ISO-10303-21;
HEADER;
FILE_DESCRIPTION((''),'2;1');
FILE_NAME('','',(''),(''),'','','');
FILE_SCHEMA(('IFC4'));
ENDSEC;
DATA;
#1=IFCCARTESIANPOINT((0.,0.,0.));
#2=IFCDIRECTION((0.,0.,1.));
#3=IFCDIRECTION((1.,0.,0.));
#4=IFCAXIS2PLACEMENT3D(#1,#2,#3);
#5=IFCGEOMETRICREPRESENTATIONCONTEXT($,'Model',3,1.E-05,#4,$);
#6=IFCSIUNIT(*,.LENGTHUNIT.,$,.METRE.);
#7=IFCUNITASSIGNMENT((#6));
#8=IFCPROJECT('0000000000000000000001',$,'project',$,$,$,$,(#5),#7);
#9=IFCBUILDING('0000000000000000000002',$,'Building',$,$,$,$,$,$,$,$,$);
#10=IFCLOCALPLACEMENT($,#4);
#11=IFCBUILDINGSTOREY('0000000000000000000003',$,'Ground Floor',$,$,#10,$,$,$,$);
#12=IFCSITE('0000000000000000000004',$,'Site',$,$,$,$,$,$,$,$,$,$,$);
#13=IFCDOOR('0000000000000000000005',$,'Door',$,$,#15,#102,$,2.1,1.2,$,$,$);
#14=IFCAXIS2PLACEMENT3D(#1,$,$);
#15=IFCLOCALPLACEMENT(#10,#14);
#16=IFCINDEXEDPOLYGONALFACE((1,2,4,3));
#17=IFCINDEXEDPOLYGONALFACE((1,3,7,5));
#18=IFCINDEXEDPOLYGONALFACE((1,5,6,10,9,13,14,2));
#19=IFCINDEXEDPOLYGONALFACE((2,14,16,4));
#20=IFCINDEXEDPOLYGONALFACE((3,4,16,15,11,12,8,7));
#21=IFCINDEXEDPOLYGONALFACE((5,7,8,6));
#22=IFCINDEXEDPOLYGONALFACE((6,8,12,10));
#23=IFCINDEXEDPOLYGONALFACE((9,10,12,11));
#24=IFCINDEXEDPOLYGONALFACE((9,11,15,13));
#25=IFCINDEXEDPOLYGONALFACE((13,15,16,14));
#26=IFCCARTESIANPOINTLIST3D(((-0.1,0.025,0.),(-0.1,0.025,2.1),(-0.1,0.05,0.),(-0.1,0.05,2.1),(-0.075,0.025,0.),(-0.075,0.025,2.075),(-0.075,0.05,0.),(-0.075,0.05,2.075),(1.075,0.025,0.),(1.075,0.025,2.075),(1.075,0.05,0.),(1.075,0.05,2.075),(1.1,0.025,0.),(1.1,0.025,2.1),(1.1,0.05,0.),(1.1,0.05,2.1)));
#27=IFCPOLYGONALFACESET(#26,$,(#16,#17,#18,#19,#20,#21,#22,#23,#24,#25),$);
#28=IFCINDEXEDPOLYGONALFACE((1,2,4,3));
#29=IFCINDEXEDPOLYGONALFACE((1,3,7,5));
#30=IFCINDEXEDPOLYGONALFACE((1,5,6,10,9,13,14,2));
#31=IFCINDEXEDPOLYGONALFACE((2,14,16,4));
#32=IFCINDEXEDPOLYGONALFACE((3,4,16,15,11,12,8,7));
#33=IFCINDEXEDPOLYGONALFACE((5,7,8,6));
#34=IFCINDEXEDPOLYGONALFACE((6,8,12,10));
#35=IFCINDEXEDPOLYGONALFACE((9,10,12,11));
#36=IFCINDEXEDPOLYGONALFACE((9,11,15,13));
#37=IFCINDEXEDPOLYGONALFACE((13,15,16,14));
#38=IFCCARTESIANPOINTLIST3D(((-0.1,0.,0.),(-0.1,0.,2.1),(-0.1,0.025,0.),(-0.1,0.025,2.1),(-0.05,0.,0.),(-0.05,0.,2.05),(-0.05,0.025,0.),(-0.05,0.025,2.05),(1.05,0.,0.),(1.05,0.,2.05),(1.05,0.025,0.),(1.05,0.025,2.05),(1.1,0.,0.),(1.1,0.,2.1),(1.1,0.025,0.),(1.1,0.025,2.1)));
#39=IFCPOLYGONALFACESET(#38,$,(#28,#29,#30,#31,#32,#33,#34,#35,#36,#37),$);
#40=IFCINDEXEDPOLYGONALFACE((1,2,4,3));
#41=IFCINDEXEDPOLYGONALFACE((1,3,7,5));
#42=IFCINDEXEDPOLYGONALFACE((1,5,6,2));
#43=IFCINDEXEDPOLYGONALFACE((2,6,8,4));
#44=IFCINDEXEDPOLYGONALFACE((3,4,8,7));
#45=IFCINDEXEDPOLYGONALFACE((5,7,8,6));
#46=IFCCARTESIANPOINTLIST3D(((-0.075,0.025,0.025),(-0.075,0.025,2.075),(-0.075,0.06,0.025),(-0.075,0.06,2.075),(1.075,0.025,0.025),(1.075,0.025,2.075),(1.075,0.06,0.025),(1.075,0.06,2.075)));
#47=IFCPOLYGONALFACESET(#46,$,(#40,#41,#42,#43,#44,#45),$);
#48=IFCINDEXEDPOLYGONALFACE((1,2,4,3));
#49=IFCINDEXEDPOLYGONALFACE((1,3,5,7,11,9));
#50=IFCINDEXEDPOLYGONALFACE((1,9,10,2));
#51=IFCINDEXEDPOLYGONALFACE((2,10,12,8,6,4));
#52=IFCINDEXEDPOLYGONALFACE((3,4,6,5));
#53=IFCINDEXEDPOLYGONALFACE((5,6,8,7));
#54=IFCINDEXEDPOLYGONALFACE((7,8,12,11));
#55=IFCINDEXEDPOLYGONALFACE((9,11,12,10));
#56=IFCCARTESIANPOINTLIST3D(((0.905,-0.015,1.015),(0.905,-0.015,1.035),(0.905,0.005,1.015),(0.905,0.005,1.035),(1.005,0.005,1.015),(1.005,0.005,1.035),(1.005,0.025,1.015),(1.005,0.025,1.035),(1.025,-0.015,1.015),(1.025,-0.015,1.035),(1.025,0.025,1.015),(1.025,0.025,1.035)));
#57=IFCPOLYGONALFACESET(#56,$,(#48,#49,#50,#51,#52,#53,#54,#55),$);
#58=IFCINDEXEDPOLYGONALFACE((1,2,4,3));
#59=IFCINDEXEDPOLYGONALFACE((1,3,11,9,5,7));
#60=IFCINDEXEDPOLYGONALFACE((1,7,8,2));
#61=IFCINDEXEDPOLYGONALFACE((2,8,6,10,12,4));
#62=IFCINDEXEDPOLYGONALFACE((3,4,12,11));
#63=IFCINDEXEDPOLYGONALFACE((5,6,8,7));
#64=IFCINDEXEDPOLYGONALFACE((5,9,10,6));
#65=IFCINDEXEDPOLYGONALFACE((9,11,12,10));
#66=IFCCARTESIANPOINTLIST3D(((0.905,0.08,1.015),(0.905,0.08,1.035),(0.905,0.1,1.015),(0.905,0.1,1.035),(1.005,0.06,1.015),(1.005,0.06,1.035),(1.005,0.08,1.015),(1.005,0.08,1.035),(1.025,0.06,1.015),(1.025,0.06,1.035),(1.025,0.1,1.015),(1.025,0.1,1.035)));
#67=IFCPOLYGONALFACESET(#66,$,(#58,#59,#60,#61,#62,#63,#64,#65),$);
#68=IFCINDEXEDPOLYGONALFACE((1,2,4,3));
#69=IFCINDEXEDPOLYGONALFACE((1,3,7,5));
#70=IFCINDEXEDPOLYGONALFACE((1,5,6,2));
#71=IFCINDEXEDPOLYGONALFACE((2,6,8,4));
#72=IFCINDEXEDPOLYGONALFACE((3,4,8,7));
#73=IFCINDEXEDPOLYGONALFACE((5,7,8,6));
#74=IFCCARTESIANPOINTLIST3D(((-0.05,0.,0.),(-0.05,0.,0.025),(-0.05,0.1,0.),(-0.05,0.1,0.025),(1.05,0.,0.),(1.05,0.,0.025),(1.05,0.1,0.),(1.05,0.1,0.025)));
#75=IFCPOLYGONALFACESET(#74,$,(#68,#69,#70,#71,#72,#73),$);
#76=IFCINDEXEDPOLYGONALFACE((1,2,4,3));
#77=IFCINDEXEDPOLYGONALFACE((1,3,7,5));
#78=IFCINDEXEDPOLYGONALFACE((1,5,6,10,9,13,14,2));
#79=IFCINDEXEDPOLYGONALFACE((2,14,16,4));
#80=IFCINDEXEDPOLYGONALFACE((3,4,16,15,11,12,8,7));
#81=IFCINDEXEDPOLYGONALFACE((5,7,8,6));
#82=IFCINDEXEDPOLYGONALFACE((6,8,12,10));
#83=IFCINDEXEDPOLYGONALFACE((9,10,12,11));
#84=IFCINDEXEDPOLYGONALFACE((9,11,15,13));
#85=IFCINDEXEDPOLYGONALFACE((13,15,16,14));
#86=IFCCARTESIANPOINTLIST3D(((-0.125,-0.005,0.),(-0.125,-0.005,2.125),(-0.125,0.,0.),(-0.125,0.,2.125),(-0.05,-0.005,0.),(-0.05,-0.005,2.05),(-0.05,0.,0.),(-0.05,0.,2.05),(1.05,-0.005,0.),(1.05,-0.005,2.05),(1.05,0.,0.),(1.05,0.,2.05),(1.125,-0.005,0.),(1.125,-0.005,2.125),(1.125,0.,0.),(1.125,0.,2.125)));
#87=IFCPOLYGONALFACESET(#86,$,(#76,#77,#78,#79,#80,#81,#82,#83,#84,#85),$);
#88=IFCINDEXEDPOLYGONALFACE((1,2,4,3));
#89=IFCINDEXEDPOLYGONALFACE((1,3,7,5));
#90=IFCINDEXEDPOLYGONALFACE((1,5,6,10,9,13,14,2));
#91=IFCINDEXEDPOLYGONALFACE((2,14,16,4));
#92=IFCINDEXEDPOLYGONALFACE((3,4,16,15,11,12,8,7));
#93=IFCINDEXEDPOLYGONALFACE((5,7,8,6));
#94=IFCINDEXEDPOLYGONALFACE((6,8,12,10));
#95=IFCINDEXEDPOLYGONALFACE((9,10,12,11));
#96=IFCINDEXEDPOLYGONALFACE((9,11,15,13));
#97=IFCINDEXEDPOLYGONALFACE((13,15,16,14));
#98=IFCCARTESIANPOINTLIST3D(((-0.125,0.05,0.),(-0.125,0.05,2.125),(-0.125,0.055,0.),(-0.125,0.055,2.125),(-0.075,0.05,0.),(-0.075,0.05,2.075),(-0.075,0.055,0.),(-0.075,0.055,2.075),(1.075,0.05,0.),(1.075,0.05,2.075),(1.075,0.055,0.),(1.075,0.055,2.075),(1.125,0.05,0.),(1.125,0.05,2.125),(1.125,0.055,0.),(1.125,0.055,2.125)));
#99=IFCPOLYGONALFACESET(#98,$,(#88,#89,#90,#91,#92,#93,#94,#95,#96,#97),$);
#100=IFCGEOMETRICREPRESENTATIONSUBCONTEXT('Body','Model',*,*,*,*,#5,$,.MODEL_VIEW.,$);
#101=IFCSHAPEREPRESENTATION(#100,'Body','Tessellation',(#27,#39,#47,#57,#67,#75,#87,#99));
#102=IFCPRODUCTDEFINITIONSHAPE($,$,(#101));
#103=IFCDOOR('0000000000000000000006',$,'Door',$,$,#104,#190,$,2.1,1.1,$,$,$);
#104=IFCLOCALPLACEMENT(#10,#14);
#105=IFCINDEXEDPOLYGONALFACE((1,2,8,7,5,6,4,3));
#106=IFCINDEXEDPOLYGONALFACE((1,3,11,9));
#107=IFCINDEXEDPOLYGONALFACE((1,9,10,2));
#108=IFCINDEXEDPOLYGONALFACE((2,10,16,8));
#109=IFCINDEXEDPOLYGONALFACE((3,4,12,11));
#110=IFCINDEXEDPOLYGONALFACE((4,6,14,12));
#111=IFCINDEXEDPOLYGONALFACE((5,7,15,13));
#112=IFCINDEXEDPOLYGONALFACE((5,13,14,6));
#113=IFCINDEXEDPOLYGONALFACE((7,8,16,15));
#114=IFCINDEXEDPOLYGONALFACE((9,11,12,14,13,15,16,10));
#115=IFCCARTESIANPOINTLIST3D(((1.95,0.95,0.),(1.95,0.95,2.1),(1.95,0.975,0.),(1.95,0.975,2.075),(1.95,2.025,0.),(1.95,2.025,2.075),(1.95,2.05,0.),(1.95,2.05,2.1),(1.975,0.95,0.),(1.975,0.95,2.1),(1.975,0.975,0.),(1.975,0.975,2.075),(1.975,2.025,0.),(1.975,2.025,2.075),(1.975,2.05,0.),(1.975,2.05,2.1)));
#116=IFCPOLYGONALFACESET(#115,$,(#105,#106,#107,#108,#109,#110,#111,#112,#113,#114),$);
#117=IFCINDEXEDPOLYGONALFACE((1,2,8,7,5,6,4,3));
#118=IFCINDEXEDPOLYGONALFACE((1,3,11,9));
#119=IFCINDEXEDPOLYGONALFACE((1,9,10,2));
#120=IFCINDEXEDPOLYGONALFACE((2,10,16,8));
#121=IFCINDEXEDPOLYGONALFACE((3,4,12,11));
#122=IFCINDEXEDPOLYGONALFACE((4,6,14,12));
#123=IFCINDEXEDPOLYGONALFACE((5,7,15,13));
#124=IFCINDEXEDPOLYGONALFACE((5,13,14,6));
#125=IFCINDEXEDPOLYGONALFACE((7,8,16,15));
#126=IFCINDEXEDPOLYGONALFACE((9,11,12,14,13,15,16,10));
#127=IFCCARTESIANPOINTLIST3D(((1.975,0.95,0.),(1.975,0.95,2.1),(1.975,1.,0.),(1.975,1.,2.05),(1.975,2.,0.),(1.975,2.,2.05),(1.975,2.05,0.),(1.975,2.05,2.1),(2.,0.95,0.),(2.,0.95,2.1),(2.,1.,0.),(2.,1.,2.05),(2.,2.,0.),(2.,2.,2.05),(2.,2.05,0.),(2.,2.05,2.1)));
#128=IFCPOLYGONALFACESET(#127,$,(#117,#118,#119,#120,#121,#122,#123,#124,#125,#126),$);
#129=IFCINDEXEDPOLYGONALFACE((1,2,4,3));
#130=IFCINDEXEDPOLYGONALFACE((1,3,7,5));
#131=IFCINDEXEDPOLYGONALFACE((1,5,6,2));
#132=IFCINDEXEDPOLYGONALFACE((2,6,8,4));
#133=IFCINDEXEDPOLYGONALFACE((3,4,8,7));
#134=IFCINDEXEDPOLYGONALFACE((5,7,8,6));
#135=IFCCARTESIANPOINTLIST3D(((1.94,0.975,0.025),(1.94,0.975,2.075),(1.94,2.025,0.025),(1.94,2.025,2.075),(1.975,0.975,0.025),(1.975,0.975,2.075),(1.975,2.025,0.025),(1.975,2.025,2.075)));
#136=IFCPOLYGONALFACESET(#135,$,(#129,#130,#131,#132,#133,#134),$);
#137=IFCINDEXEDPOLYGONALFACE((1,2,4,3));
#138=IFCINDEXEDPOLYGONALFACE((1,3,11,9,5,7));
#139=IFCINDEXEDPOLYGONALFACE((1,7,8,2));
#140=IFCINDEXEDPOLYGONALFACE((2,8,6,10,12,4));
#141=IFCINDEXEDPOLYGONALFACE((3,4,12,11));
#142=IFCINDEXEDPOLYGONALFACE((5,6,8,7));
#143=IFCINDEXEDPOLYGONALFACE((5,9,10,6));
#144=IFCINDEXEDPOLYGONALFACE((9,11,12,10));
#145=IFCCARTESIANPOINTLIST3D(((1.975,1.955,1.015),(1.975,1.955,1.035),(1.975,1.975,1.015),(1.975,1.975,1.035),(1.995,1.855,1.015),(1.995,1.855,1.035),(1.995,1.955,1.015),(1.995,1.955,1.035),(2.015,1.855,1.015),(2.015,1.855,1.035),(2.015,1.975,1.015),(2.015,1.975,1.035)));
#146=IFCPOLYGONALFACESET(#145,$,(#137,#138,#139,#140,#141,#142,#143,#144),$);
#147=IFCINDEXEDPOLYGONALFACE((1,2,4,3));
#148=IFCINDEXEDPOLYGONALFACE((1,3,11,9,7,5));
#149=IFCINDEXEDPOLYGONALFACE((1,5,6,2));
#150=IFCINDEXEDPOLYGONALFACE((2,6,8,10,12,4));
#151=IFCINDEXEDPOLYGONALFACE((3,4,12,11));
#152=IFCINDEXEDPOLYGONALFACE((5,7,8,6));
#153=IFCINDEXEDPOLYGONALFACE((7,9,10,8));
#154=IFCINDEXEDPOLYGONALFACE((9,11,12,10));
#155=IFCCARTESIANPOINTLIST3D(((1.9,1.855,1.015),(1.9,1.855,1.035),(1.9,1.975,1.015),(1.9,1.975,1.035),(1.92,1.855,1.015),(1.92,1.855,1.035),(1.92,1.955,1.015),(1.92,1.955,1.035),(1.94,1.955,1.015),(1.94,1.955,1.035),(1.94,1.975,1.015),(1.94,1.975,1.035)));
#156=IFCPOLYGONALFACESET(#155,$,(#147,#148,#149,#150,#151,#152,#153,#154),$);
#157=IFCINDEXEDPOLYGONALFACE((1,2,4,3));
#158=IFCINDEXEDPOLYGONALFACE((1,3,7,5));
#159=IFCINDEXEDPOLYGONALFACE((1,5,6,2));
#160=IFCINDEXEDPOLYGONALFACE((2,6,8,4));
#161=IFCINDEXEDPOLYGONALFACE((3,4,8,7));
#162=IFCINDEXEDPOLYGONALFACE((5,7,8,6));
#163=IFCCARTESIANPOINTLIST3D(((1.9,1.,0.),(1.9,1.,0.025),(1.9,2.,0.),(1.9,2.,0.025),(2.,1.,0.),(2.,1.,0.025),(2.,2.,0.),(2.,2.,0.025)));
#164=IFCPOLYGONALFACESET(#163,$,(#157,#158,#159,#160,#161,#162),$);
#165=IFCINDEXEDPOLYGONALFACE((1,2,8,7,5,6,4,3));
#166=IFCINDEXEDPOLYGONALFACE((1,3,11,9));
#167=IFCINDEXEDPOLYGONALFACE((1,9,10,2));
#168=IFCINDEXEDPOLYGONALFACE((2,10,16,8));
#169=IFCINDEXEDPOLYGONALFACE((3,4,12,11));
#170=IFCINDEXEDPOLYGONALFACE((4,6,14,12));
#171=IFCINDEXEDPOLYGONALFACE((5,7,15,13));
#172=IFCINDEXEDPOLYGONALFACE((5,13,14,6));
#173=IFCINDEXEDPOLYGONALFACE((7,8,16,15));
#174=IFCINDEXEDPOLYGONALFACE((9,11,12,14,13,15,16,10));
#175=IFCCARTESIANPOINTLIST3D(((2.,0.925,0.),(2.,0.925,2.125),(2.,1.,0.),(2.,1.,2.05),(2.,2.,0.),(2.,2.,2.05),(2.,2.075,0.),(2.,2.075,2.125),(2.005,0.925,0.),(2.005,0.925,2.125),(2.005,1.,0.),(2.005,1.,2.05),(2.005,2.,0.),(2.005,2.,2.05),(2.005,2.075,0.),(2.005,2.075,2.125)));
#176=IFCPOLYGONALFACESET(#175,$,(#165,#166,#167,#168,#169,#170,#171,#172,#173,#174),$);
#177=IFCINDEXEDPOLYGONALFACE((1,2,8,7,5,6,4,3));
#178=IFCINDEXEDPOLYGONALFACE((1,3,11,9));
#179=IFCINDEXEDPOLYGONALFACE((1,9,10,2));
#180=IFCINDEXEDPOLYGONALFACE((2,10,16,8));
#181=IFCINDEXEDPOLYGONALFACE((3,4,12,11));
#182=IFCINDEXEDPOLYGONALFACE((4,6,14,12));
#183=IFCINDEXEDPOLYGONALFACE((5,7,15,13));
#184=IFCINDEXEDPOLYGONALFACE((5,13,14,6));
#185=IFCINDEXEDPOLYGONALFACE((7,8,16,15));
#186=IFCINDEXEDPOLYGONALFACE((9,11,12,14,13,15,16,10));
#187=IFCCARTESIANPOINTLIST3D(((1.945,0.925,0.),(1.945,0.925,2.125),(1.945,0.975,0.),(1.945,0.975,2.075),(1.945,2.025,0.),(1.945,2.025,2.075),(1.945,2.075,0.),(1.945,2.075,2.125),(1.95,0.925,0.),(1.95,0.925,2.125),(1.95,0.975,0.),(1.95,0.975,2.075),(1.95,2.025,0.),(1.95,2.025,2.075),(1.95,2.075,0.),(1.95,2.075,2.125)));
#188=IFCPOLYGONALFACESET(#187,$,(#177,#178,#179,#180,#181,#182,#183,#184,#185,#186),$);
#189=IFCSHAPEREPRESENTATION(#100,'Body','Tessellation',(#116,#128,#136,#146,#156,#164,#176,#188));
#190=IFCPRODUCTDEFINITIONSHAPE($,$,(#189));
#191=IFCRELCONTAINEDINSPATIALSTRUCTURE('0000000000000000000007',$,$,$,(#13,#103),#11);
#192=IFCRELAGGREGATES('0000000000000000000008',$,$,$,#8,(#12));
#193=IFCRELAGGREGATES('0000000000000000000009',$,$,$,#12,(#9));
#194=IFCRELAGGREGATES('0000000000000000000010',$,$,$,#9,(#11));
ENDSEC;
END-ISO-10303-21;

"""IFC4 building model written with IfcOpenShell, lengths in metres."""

from ifc_helpers import new_model, si_unit, frame, origin_with_axes, place, context, subcontext, project, spatial, line, indexed_curve, outline, extrude, element, save


model = new_model("IFC4")

# Units and contexts
model_context = context("Model", 3, precision=1e-05, world=origin_with_axes())
body_context = subcontext(model_context, "Body", "Model", "MODEL_VIEW")
ifc_project = project(units=[si_unit("LENGTHUNIT", "METRE")], contexts=[model_context])

# Site, building, storey
site = spatial("IfcSite", under=ifc_project, Name="Site")
building = spatial("IfcBuilding", under=site, Name="Building")
storey_placement = place(None, origin_with_axes())
storey = spatial("IfcBuildingStorey", under=building, at=storey_placement, Name="Ground Floor")

# Doors
door_1_placement = place(storey_placement, frame((-0.1, 0.0, 0.0), z_axis=(0.0, 0.0, 1.0), x_axis=(1.0, 0.0, 0.0)))
element("IfcDoor", 1, at=door_1_placement, inside=storey, Name="Door", OverallHeight=2.1, OverallWidth=1.2, context=body_context, shape_type="SweptSolid", body=[
    extrude(outline(indexed_curve([(0.0, 0.0), (0.0, 2.1), (1.2, 2.1), (1.2, 0.0), (1.175, 0.0), (1.175, 2.075), (0.025, 2.075), (0.025, 0.0)], segments=[line(1, 2, 3, 4, 5, 6, 7, 8, 1)])), frame((0.0, 0.025, 0.0), z_axis=(0.0, -1.0, 0.0), x_axis=(1.0, 0.0, 0.0)), (0.0, 0.0, -1.0), 0.025),
    extrude(outline(indexed_curve([(0.0, 0.0), (0.0, 2.1), (1.2, 2.1), (1.2, 0.0), (1.15, 0.0), (1.15, 2.05), (0.05, 2.05), (0.05, 0.0)], segments=[line(1, 2, 3, 4, 5, 6, 7, 8, 1)])), frame((0.0, 0.0, 0.0), z_axis=(0.0, -1.0, 0.0), x_axis=(1.0, 0.0, 0.0)), (0.0, 0.0, -1.0), 0.025),
    extrude(outline(indexed_curve([(0.0, 0.0), (1.15, 0.0), (1.15, 0.035), (0.0, 0.035)], segments=[line(1, 2, 3, 4, 1)])), frame((0.025, 0.025, 0.025), z_axis=(0.0, 0.0, 1.0), x_axis=(1.0, 0.0, 0.0)), (0.0, 0.0, 1.0), 2.05),
    extrude(outline(indexed_curve([(0.0, 0.0), (0.0, -0.04), (-0.12, -0.04), (-0.12, -0.02), (-0.02, -0.02), (-0.02, 0.0)], segments=[line(1, 2, 3, 4, 5, 6, 1)])), frame((1.125, 0.025, 1.015), z_axis=(0.0, 0.0, 1.0), x_axis=(1.0, 0.0, 0.0)), (0.0, 0.0, 1.0), 0.02),
    extrude(outline(indexed_curve([(0.0, 0.0), (0.0, 0.04), (-0.12, 0.04), (-0.12, 0.02), (-0.02, 0.02), (-0.02, 0.0)], segments=[line(1, 2, 3, 4, 5, 6, 1)])), frame((1.125, 0.06, 1.015), z_axis=(0.0, 0.0, 1.0), x_axis=(1.0, 0.0, 0.0)), (0.0, 0.0, 1.0), 0.02),
    extrude(outline(indexed_curve([(0.0, 0.0), (1.1, 0.0), (1.1, 0.1), (0.0, 0.1)], segments=[line(1, 2, 3, 4, 1)])), frame((0.05, 0.0, 0.0), z_axis=(0.0, 0.0, 1.0), x_axis=(1.0, 0.0, 0.0)), (0.0, 0.0, 1.0), 0.025),
    extrude(outline(indexed_curve([(0.0, 0.0), (0.0, 2.125), (1.25, 2.125), (1.25, 0.0), (1.175, 0.0), (1.175, 2.05), (0.075, 2.05), (0.075, 0.0)], segments=[line(1, 2, 3, 4, 5, 6, 7, 8, 1)])), frame((-0.025, -0.005, 0.0), z_axis=(0.0, -1.0, 0.0), x_axis=(1.0, 0.0, 0.0)), (0.0, 0.0, -1.0), 0.005),
    extrude(outline(indexed_curve([(0.0, 0.0), (0.0, 2.125), (1.25, 2.125), (1.25, 0.0), (1.2, 0.0), (1.2, 2.075), (0.05, 2.075), (0.05, 0.0)], segments=[line(1, 2, 3, 4, 5, 6, 7, 8, 1)])), frame((-0.025, 0.05, 0.0), z_axis=(0.0, -1.0, 0.0), x_axis=(1.0, 0.0, 0.0)), (0.0, 0.0, -1.0), 0.005),
])
door_2_placement = place(storey_placement, frame((2.0, 0.95, 0.0), z_axis=(0.0, 0.0, 1.0), x_axis=(0.0, 1.0, 0.0)))
element("IfcDoor", 2, at=door_2_placement, inside=storey, Name="Door", OverallHeight=2.1, OverallWidth=1.1, context=body_context, shape_type="SweptSolid", body=[
    extrude(outline(indexed_curve([(0.0, 0.0), (0.0, 2.1), (1.1, 2.1), (1.1, 0.0), (1.075, 0.0), (1.075, 2.075), (0.025, 2.075), (0.025, 0.0)], segments=[line(1, 2, 3, 4, 5, 6, 7, 8, 1)])), frame((0.0, 0.025, 0.0), z_axis=(0.0, -1.0, 0.0), x_axis=(1.0, 0.0, 0.0)), (0.0, 0.0, -1.0), 0.025),
    extrude(outline(indexed_curve([(0.0, 0.0), (0.0, 2.1), (1.1, 2.1), (1.1, 0.0), (1.05, 0.0), (1.05, 2.05), (0.05, 2.05), (0.05, 0.0)], segments=[line(1, 2, 3, 4, 5, 6, 7, 8, 1)])), frame((0.0, 0.0, 0.0), z_axis=(0.0, -1.0, 0.0), x_axis=(1.0, 0.0, 0.0)), (0.0, 0.0, -1.0), 0.025),
    extrude(outline(indexed_curve([(0.0, 0.0), (1.05, 0.0), (1.05, 0.035), (0.0, 0.035)], segments=[line(1, 2, 3, 4, 1)])), frame((0.025, 0.025, 0.025), z_axis=(0.0, 0.0, 1.0), x_axis=(1.0, 0.0, 0.0)), (0.0, 0.0, 1.0), 2.05),
    extrude(outline(indexed_curve([(0.0, 0.0), (0.0, -0.04), (-0.12, -0.04), (-0.12, -0.02), (-0.02, -0.02), (-0.02, 0.0)], segments=[line(1, 2, 3, 4, 5, 6, 1)])), frame((1.025, 0.025, 1.015), z_axis=(0.0, 0.0, 1.0), x_axis=(1.0, 0.0, 0.0)), (0.0, 0.0, 1.0), 0.02),
    extrude(outline(indexed_curve([(0.0, 0.0), (0.0, 0.04), (-0.12, 0.04), (-0.12, 0.02), (-0.02, 0.02), (-0.02, 0.0)], segments=[line(1, 2, 3, 4, 5, 6, 1)])), frame((1.025, 0.06, 1.015), z_axis=(0.0, 0.0, 1.0), x_axis=(1.0, 0.0, 0.0)), (0.0, 0.0, 1.0), 0.02),
    extrude(outline(indexed_curve([(0.0, 0.0), (1.0, 0.0), (1.0, 0.1), (0.0, 0.1)], segments=[line(1, 2, 3, 4, 1)])), frame((0.05, 0.0, 0.0), z_axis=(0.0, 0.0, 1.0), x_axis=(1.0, 0.0, 0.0)), (0.0, 0.0, 1.0), 0.025),
    extrude(outline(indexed_curve([(0.0, 0.0), (0.0, 2.125), (1.15, 2.125), (1.15, 0.0), (1.075, 0.0), (1.075, 2.05), (0.075, 2.05), (0.075, 0.0)], segments=[line(1, 2, 3, 4, 5, 6, 7, 8, 1)])), frame((-0.025, -0.005, 0.0), z_axis=(0.0, -1.0, 0.0), x_axis=(1.0, 0.0, 0.0)), (0.0, 0.0, -1.0), 0.005),
    extrude(outline(indexed_curve([(0.0, 0.0), (0.0, 2.125), (1.15, 2.125), (1.15, 0.0), (1.1, 0.0), (1.1, 2.075), (0.05, 2.075), (0.05, 0.0)], segments=[line(1, 2, 3, 4, 5, 6, 7, 8, 1)])), frame((-0.025, 0.05, 0.0), z_axis=(0.0, -1.0, 0.0), x_axis=(1.0, 0.0, 0.0)), (0.0, 0.0, -1.0), 0.005),
])

save(model, "model.ifc")
